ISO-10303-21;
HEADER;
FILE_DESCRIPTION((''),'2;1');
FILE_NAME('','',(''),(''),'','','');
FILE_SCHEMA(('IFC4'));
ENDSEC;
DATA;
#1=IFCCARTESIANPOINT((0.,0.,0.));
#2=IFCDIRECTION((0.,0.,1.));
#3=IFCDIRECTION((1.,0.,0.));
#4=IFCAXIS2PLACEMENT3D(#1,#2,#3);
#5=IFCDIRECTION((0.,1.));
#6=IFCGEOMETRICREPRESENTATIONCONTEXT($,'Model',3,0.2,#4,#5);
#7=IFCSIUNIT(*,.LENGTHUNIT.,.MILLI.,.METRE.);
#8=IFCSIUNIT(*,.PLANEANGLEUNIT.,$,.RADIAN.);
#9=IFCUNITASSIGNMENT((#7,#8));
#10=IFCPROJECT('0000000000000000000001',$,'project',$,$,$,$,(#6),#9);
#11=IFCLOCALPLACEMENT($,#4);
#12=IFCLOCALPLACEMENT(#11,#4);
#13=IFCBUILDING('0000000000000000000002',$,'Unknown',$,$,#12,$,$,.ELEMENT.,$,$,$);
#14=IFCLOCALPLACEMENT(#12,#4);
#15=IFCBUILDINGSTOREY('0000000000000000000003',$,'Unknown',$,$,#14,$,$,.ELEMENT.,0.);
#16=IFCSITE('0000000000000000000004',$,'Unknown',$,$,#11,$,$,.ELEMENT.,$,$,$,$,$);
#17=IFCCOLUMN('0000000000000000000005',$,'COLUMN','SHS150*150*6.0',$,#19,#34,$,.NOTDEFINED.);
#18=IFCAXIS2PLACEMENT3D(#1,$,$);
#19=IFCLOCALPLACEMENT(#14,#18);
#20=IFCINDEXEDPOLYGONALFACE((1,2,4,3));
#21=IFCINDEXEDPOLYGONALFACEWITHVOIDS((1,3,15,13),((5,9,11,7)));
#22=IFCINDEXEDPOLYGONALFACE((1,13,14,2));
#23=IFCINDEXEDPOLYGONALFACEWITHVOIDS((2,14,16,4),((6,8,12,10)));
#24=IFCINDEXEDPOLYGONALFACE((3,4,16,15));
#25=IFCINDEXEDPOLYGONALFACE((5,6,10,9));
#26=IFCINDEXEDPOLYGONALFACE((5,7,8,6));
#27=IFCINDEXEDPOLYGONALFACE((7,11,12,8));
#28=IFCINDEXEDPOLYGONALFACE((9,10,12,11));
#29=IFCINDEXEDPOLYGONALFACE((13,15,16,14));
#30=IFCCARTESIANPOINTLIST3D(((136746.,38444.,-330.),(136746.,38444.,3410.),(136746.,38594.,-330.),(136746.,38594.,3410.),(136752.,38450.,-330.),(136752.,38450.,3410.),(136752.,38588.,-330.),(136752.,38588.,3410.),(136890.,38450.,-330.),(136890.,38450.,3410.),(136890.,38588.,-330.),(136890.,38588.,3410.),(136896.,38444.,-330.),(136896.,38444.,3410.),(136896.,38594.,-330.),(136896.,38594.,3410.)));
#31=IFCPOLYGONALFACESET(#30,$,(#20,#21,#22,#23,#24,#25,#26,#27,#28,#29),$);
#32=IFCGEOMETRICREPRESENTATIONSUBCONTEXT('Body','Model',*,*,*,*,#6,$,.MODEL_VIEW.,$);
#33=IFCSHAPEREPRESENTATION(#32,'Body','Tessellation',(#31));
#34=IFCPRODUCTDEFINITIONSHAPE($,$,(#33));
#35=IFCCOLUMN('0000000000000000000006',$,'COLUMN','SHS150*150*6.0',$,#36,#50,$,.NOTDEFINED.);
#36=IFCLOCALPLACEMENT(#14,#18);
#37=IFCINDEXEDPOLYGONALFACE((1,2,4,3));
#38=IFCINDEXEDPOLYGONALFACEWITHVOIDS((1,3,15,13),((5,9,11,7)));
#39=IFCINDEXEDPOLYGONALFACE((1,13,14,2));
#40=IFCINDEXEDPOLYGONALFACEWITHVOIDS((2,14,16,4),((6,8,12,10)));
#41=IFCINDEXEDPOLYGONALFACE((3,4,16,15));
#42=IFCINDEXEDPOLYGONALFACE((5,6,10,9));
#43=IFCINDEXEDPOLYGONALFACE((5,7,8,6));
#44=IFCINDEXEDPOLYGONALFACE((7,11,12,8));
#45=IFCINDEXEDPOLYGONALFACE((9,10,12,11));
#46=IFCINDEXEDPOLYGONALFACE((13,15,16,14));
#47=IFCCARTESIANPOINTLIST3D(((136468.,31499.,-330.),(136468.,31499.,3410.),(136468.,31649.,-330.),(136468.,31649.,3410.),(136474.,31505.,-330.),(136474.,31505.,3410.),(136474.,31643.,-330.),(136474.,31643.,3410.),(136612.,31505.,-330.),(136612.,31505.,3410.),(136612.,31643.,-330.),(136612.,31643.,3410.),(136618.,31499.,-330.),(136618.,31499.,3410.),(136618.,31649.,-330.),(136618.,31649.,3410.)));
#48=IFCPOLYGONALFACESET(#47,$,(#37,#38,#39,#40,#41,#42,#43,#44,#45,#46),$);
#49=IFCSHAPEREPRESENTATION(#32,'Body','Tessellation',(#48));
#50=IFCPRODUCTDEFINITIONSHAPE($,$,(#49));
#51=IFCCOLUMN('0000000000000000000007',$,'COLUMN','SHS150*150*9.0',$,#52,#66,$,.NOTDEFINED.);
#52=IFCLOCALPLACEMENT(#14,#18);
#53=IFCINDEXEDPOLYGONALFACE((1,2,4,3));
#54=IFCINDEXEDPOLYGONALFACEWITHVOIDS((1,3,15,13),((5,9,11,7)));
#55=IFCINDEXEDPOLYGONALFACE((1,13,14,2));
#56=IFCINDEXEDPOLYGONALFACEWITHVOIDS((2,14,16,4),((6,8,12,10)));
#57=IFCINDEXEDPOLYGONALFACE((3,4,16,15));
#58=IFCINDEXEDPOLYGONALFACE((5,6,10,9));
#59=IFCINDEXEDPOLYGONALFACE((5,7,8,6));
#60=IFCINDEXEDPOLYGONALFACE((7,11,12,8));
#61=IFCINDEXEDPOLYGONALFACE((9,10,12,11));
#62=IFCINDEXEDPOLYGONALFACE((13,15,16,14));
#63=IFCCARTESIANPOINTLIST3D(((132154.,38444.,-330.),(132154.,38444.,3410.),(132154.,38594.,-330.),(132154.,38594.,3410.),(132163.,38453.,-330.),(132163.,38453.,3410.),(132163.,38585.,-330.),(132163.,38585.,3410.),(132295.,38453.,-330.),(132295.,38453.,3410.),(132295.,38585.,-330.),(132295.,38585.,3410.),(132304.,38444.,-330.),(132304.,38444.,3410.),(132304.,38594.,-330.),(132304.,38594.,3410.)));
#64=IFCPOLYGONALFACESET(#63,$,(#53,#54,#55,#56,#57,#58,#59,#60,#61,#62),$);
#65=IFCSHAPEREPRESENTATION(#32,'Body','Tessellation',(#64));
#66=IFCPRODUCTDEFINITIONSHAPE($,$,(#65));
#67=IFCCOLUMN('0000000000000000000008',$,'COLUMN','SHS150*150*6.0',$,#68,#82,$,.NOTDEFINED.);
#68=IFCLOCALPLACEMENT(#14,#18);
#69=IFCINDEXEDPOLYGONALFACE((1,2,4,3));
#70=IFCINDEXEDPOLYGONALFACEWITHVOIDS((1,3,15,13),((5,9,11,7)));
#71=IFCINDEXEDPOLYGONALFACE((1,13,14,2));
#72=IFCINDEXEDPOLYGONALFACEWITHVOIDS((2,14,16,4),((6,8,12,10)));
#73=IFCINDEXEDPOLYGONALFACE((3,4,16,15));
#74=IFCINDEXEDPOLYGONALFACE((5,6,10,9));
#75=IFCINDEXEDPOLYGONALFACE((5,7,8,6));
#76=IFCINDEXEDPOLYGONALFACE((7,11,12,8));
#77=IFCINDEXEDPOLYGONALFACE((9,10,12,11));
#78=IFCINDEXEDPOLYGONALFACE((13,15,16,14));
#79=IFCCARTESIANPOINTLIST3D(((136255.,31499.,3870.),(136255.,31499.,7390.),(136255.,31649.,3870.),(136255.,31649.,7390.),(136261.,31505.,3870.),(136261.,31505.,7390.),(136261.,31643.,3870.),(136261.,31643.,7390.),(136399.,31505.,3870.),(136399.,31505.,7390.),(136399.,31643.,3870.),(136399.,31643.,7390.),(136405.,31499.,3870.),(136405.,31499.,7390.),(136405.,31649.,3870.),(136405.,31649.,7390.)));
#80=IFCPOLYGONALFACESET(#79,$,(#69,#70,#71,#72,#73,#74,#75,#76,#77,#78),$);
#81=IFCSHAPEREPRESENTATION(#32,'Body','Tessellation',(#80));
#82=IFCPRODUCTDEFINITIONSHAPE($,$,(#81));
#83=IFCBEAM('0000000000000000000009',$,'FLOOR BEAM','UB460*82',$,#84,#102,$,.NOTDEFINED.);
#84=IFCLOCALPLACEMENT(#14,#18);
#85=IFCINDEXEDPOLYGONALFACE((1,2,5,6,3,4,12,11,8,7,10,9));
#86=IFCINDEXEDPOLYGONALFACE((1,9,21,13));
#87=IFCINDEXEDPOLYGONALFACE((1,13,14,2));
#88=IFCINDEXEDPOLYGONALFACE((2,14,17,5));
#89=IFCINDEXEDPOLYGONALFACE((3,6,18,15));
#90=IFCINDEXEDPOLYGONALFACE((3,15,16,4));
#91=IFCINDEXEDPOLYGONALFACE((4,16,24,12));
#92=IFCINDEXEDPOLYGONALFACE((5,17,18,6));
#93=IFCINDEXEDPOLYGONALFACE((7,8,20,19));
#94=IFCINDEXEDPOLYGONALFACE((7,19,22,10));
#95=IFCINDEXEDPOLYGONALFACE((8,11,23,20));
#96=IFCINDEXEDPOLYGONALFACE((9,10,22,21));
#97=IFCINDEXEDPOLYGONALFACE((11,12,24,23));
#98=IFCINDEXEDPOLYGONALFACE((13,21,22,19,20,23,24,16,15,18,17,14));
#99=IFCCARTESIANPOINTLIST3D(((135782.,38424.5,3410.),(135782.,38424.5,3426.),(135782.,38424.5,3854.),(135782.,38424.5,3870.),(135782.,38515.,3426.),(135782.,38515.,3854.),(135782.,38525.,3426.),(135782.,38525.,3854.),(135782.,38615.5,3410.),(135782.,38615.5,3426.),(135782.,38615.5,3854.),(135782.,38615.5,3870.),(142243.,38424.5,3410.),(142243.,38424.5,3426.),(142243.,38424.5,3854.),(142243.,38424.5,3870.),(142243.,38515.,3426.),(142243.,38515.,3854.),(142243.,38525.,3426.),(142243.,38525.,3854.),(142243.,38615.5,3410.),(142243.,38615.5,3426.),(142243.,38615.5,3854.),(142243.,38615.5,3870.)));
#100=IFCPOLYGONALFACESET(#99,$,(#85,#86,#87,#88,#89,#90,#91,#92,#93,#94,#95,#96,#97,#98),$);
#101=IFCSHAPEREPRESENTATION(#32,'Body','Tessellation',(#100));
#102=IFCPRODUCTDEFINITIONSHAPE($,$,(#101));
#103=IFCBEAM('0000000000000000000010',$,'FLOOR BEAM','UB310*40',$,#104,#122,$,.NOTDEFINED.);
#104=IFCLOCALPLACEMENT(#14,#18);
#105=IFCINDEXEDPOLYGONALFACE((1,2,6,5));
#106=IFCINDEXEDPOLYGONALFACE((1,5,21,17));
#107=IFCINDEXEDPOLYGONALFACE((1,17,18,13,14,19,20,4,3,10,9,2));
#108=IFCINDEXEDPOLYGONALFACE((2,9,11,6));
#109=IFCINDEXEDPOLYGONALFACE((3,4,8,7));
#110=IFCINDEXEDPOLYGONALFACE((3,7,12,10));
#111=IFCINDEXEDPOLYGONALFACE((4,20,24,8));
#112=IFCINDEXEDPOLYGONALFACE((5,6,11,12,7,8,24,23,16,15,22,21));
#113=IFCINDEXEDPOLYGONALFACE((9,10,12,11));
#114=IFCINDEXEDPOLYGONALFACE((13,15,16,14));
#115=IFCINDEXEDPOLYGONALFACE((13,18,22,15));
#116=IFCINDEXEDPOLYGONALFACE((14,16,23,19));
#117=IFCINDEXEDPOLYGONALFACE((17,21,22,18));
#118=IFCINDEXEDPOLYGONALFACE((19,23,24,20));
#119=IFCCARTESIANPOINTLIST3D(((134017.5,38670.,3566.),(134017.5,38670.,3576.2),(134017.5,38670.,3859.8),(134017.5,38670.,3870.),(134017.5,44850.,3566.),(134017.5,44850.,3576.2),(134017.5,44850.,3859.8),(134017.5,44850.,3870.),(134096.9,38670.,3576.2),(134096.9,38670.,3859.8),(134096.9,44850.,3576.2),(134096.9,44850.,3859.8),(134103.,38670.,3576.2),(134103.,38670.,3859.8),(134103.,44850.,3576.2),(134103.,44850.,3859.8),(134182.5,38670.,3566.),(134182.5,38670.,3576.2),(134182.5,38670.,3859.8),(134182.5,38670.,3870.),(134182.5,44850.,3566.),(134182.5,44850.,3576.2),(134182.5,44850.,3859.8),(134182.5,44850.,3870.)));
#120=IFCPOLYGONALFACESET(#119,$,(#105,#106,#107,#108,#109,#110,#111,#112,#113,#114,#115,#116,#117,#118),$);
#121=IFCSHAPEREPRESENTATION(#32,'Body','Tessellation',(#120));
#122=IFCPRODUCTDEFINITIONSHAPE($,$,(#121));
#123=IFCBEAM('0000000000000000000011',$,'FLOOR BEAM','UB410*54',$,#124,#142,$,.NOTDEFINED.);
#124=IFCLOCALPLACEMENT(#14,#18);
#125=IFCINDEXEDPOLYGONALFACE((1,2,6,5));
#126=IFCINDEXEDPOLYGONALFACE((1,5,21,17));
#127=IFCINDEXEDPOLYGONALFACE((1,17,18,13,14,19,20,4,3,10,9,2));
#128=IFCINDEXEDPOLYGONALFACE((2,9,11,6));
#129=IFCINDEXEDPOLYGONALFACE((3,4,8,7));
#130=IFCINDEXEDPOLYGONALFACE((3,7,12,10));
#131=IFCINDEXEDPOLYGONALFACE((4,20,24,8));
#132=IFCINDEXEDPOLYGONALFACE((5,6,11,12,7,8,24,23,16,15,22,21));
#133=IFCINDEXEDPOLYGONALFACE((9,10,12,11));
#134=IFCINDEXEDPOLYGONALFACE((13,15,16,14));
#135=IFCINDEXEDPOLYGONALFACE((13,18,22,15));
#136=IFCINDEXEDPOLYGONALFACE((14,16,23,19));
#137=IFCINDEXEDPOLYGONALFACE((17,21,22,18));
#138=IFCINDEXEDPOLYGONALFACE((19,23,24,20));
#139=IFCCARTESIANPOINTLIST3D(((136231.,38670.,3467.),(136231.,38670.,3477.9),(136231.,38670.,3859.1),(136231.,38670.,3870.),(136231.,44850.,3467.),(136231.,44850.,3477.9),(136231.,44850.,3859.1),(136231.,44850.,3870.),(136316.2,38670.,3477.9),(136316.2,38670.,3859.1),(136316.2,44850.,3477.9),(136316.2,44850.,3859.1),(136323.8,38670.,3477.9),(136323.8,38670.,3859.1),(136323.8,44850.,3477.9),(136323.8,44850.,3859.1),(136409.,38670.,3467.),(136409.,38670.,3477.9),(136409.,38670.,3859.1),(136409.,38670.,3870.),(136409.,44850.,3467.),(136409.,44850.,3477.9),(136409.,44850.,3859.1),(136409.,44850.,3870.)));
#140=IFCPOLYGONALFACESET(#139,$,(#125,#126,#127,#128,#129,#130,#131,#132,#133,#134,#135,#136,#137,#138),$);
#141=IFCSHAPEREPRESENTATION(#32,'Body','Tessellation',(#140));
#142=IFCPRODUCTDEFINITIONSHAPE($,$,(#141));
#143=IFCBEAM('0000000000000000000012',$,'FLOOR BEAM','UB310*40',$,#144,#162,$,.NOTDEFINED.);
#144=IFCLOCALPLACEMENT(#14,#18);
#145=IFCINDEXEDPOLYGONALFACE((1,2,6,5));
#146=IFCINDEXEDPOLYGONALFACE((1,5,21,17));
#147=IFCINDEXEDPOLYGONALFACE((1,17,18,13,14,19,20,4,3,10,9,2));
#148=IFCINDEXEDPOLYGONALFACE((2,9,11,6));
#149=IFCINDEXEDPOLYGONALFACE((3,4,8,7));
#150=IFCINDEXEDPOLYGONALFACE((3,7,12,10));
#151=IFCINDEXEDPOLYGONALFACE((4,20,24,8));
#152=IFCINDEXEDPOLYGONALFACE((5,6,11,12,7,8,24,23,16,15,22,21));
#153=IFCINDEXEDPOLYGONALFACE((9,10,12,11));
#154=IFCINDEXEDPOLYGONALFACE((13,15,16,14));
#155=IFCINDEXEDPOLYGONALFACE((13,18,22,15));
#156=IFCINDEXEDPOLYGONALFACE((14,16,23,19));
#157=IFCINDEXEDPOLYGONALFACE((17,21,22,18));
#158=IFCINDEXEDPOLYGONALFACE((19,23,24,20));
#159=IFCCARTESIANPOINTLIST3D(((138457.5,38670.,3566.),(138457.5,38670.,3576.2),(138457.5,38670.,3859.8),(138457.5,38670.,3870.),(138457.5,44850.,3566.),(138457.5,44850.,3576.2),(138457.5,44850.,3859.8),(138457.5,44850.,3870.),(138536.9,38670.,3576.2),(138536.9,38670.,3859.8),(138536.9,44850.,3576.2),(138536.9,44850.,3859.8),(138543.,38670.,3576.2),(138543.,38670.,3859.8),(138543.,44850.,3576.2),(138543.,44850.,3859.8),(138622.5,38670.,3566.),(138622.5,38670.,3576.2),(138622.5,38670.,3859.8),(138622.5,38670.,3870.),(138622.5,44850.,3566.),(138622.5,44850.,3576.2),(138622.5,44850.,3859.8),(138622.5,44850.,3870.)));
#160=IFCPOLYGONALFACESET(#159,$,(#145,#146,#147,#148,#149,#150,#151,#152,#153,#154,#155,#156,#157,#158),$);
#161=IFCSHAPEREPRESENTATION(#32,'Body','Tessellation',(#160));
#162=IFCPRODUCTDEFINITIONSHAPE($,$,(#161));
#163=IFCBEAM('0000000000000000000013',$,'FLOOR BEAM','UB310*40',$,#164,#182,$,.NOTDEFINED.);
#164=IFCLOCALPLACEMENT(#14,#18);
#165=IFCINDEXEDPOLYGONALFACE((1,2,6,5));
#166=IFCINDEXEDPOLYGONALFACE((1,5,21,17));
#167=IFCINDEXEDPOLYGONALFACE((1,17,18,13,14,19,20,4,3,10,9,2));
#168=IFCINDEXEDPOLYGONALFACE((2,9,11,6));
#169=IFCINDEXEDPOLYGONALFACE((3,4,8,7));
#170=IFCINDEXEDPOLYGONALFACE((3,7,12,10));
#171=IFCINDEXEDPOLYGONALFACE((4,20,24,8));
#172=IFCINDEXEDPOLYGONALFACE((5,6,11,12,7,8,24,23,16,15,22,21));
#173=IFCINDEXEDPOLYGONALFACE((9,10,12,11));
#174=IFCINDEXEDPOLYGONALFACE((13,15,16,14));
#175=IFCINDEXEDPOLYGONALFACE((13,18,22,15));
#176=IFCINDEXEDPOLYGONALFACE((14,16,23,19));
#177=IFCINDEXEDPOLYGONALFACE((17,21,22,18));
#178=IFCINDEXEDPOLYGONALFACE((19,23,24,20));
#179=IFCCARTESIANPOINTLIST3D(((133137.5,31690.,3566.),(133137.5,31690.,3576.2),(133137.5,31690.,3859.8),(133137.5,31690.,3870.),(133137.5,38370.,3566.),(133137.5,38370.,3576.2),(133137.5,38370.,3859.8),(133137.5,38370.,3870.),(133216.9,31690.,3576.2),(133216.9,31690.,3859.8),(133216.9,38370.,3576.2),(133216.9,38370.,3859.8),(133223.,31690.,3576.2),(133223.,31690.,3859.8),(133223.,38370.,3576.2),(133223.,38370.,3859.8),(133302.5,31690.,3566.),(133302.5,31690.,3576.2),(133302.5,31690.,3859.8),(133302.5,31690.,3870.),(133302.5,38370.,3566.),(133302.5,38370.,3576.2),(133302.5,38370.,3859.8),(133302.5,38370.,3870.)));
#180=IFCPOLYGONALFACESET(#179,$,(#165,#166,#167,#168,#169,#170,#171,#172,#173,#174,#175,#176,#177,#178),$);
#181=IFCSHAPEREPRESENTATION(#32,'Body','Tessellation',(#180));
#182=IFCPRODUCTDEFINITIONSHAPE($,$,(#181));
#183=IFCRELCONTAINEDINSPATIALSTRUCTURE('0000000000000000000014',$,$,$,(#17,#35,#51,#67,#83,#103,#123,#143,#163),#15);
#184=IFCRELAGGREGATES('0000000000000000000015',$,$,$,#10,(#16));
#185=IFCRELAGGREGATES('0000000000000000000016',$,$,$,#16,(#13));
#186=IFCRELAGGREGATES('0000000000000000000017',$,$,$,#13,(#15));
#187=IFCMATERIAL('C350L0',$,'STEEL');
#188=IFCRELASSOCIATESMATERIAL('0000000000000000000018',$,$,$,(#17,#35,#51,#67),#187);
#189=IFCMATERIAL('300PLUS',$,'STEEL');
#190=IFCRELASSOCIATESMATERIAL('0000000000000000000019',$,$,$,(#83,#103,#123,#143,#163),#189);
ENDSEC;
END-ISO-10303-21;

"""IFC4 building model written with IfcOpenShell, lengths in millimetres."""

from ifc_helpers import new_model, si_unit, direction, frame, origin_with_axes, place, context, subcontext, project, spatial, line, indexed_curve, outline, extrude, material, element, save


model = new_model("IFC4")

# Units and contexts
model_context = context("Model", 3, precision=0.2, world=origin_with_axes(), true_north=direction((0.0, 1.0)))
body_context = subcontext(model_context, "Body", "Model", "MODEL_VIEW")
ifc_project = project(units=[si_unit("LENGTHUNIT", "METRE", prefix="MILLI"), si_unit("PLANEANGLEUNIT", "RADIAN")], contexts=[model_context])

# Site, building, storey
site_placement = place(None, origin_with_axes())
site = spatial("IfcSite", under=ifc_project, at=site_placement, Name="Unknown", CompositionType="ELEMENT")
building_placement = place(site_placement, origin_with_axes())
building = spatial("IfcBuilding", under=site, at=building_placement, Name="Unknown", CompositionType="ELEMENT")
storey_placement = place(building_placement, origin_with_axes())
storey = spatial("IfcBuildingStorey", under=building, at=storey_placement, Name="Unknown", CompositionType="ELEMENT", Elevation=0.0)

# Columns
ifc_material_1 = material(Name="C350L0", Category="STEEL")
for number, where, z_axis, x_axis, name in (
    (1, (136821.0, 38519.0, -330.0), (-1.0, 0.0, 0.0), (0.0, 0.0, 1.0), "COLUMN"),
    (2, (136543.0, 31574.0, -330.0), (-1.0, 0.0, 0.0), (0.0, 0.0, 1.0), "COLUMN"),
):
    element("IfcColumn", number, at=place(storey_placement, frame(where, z_axis=z_axis, x_axis=x_axis)), inside=storey, material=ifc_material_1, Name=name, Description="SHS150*150*6.0", PredefinedType="NOTDEFINED", context=body_context, shape_type="SolidModel", body=[
        extrude(outline(indexed_curve([(-75.0, -75.0), (75.0, -75.0), (75.0, 75.0), (-75.0, 75.0)], segments=[line(1, 2, 3, 4, 1)]), holes=[indexed_curve([(-69.0, -69.0), (-69.0, 69.0), (69.0, 69.0), (69.0, -69.0)], segments=[line(1, 2, 3, 4, 1)])]), frame((0.0, 0.0, 0.0), z_axis=(-1.0, 0.0, 0.0), x_axis=(0.0, 0.0, 1.0)), (0.0, 0.0, -1.0), 3740.0),
    ])
column_1_placement = place(storey_placement, frame((132229.0, 38519.0, -330.0), z_axis=(-1.0, 0.0, 0.0), x_axis=(0.0, 0.0, 1.0)))
element("IfcColumn", 3, at=column_1_placement, inside=storey, material=ifc_material_1, Name="COLUMN", Description="SHS150*150*9.0", PredefinedType="NOTDEFINED", context=body_context, shape_type="SolidModel", body=[
    extrude(outline(indexed_curve([(-75.0, -75.0), (75.0, -75.0), (75.0, 75.0), (-75.0, 75.0)], segments=[line(1, 2, 3, 4, 1)]), holes=[indexed_curve([(-66.0, -66.0), (-66.0, 66.0), (66.0, 66.0), (66.0, -66.0)], segments=[line(1, 2, 3, 4, 1)])]), frame((0.0, 0.0, 0.0), z_axis=(-1.0, 0.0, 0.0), x_axis=(0.0, 0.0, 1.0)), (0.0, 0.0, -1.0), 3740.0),
])
column_2_placement = place(storey_placement, frame((136330.0, 31574.0, 3870.0), z_axis=(-1.0, 0.0, 0.0), x_axis=(0.0, 0.0, 1.0)))
element("IfcColumn", 4, at=column_2_placement, inside=storey, material=ifc_material_1, Name="COLUMN", Description="SHS150*150*6.0", PredefinedType="NOTDEFINED", context=body_context, shape_type="SolidModel", body=[
    extrude(outline(indexed_curve([(-75.0, -75.0), (75.0, -75.0), (75.0, 75.0), (-75.0, 75.0)], segments=[line(1, 2, 3, 4, 1)]), holes=[indexed_curve([(-69.0, -69.0), (-69.0, 69.0), (69.0, 69.0), (69.0, -69.0)], segments=[line(1, 2, 3, 4, 1)])]), frame((0.0, 0.0, 0.0), z_axis=(-1.0, 0.0, 0.0), x_axis=(0.0, 0.0, 1.0)), (0.0, 0.0, -1.0), 3520.0),
])

# Beams
ifc_material_2 = material(Name="300PLUS", Category="STEEL")
beam_1_placement = place(storey_placement, frame((135782.0, 38520.0, 3640.0), z_axis=(0.0, -1.0, 0.0), x_axis=(1.0, 0.0, 0.0)))
element("IfcBeam", 5, at=beam_1_placement, inside=storey, material=ifc_material_2, Name="FLOOR BEAM", Description="UB460*82", PredefinedType="NOTDEFINED", context=body_context, shape_type="SolidModel", body=[
    extrude(outline(indexed_curve([(-95.5, -230.0), (95.5, -230.0), (95.5, -214.0), (5.0, -214.0), (5.0, 214.0), (95.5, 214.0), (95.5, 230.0), (-95.5, 230.0), (-95.5, 214.0), (-5.0, 214.0), (-5.0, -214.0), (-95.5, -214.0)], segments=[line(1, 2, 3, 4, 5, 6, 7, 8, 9, 10, 11, 12, 1)])), frame((0.0, 0.0, 0.0), z_axis=(-1.0, 0.0, 0.0), x_axis=(0.0, 0.0, 1.0)), (0.0, 0.0, -1.0), 6461.0),
])
beam_2_placement = place(storey_placement, frame((134100.0, 38670.0, 3718.0), z_axis=(1.0, 0.0, 0.0), x_axis=(0.0, 1.0, 0.0)))
element("IfcBeam", 6, at=beam_2_placement, inside=storey, material=ifc_material_2, Name="FLOOR BEAM", Description="UB310*40", PredefinedType="NOTDEFINED", context=body_context, shape_type="SolidModel", body=[
    extrude(outline(indexed_curve([(-82.5, -152.0), (82.5, -152.0), (82.5, -141.8), (3.0, -141.8), (3.0, 141.8), (82.5, 141.8), (82.5, 152.0), (-82.5, 152.0), (-82.5, 141.8), (-3.0, 141.8), (-3.0, -141.8), (-82.5, -141.8)], segments=[line(1, 2, 3, 4, 5, 6, 7, 8, 9, 10, 11, 12, 1)])), frame((0.0, 0.0, 0.0), z_axis=(-1.0, 0.0, 0.0), x_axis=(0.0, 0.0, 1.0)), (0.0, 0.0, -1.0), 6180.0),
])
beam_3_placement = place(storey_placement, frame((136320.0, 38670.0, 3668.5), z_axis=(1.0, 0.0, 0.0), x_axis=(0.0, 1.0, 0.0)))
element("IfcBeam", 7, at=beam_3_placement, inside=storey, material=ifc_material_2, Name="FLOOR BEAM", Description="UB410*54", PredefinedType="NOTDEFINED", context=body_context, shape_type="SolidModel", body=[
    extrude(outline(indexed_curve([(-89.0, -201.5), (89.0, -201.5), (89.0, -190.6), (3.8, -190.6), (3.8, 190.6), (89.0, 190.6), (89.0, 201.5), (-89.0, 201.5), (-89.0, 190.6), (-3.8, 190.6), (-3.8, -190.6), (-89.0, -190.6)], segments=[line(1, 2, 3, 4, 5, 6, 7, 8, 9, 10, 11, 12, 1)])), frame((0.0, 0.0, 0.0), z_axis=(-1.0, 0.0, 0.0), x_axis=(0.0, 0.0, 1.0)), (0.0, 0.0, -1.0), 6180.0),
])
beam_4_placement = place(storey_placement, frame((138540.0, 38670.0, 3718.0), z_axis=(1.0, 0.0, 0.0), x_axis=(0.0, 1.0, 0.0)))
element("IfcBeam", 8, at=beam_4_placement, inside=storey, material=ifc_material_2, Name="FLOOR BEAM", Description="UB310*40", PredefinedType="NOTDEFINED", context=body_context, shape_type="SolidModel", body=[
    extrude(outline(indexed_curve([(-82.5, -152.0), (82.5, -152.0), (82.5, -141.8), (3.0, -141.8), (3.0, 141.8), (82.5, 141.8), (82.5, 152.0), (-82.5, 152.0), (-82.5, 141.8), (-3.0, 141.8), (-3.0, -141.8), (-82.5, -141.8)], segments=[line(1, 2, 3, 4, 5, 6, 7, 8, 9, 10, 11, 12, 1)])), frame((0.0, 0.0, 0.0), z_axis=(-1.0, 0.0, 0.0), x_axis=(0.0, 0.0, 1.0)), (0.0, 0.0, -1.0), 6180.0),
])
for number, where, z_axis, x_axis, name in (
    (9, (133220.0, 31690.0, 3718.0), (1.0, 0.0, 0.0), (0.0, 1.0, 0.0), "FLOOR BEAM"),
):
    element("IfcBeam", number, at=place(storey_placement, frame(where, z_axis=z_axis, x_axis=x_axis)), inside=storey, material=ifc_material_2, Name=name, Description="UB310*40", PredefinedType="NOTDEFINED", context=body_context, shape_type="SolidModel", body=[
        extrude(outline(indexed_curve([(-82.5, -152.0), (82.5, -152.0), (82.5, -141.8), (3.0, -141.8), (3.0, 141.8), (82.5, 141.8), (82.5, 152.0), (-82.5, 152.0), (-82.5, 141.8), (-3.0, 141.8), (-3.0, -141.8), (-82.5, -141.8)], segments=[line(1, 2, 3, 4, 5, 6, 7, 8, 9, 10, 11, 12, 1)])), frame((0.0, 0.0, 0.0), z_axis=(-1.0, 0.0, 0.0), x_axis=(0.0, 0.0, 1.0)), (0.0, 0.0, -1.0), 6680.0),
    ])

save(model, "model.ifc")
